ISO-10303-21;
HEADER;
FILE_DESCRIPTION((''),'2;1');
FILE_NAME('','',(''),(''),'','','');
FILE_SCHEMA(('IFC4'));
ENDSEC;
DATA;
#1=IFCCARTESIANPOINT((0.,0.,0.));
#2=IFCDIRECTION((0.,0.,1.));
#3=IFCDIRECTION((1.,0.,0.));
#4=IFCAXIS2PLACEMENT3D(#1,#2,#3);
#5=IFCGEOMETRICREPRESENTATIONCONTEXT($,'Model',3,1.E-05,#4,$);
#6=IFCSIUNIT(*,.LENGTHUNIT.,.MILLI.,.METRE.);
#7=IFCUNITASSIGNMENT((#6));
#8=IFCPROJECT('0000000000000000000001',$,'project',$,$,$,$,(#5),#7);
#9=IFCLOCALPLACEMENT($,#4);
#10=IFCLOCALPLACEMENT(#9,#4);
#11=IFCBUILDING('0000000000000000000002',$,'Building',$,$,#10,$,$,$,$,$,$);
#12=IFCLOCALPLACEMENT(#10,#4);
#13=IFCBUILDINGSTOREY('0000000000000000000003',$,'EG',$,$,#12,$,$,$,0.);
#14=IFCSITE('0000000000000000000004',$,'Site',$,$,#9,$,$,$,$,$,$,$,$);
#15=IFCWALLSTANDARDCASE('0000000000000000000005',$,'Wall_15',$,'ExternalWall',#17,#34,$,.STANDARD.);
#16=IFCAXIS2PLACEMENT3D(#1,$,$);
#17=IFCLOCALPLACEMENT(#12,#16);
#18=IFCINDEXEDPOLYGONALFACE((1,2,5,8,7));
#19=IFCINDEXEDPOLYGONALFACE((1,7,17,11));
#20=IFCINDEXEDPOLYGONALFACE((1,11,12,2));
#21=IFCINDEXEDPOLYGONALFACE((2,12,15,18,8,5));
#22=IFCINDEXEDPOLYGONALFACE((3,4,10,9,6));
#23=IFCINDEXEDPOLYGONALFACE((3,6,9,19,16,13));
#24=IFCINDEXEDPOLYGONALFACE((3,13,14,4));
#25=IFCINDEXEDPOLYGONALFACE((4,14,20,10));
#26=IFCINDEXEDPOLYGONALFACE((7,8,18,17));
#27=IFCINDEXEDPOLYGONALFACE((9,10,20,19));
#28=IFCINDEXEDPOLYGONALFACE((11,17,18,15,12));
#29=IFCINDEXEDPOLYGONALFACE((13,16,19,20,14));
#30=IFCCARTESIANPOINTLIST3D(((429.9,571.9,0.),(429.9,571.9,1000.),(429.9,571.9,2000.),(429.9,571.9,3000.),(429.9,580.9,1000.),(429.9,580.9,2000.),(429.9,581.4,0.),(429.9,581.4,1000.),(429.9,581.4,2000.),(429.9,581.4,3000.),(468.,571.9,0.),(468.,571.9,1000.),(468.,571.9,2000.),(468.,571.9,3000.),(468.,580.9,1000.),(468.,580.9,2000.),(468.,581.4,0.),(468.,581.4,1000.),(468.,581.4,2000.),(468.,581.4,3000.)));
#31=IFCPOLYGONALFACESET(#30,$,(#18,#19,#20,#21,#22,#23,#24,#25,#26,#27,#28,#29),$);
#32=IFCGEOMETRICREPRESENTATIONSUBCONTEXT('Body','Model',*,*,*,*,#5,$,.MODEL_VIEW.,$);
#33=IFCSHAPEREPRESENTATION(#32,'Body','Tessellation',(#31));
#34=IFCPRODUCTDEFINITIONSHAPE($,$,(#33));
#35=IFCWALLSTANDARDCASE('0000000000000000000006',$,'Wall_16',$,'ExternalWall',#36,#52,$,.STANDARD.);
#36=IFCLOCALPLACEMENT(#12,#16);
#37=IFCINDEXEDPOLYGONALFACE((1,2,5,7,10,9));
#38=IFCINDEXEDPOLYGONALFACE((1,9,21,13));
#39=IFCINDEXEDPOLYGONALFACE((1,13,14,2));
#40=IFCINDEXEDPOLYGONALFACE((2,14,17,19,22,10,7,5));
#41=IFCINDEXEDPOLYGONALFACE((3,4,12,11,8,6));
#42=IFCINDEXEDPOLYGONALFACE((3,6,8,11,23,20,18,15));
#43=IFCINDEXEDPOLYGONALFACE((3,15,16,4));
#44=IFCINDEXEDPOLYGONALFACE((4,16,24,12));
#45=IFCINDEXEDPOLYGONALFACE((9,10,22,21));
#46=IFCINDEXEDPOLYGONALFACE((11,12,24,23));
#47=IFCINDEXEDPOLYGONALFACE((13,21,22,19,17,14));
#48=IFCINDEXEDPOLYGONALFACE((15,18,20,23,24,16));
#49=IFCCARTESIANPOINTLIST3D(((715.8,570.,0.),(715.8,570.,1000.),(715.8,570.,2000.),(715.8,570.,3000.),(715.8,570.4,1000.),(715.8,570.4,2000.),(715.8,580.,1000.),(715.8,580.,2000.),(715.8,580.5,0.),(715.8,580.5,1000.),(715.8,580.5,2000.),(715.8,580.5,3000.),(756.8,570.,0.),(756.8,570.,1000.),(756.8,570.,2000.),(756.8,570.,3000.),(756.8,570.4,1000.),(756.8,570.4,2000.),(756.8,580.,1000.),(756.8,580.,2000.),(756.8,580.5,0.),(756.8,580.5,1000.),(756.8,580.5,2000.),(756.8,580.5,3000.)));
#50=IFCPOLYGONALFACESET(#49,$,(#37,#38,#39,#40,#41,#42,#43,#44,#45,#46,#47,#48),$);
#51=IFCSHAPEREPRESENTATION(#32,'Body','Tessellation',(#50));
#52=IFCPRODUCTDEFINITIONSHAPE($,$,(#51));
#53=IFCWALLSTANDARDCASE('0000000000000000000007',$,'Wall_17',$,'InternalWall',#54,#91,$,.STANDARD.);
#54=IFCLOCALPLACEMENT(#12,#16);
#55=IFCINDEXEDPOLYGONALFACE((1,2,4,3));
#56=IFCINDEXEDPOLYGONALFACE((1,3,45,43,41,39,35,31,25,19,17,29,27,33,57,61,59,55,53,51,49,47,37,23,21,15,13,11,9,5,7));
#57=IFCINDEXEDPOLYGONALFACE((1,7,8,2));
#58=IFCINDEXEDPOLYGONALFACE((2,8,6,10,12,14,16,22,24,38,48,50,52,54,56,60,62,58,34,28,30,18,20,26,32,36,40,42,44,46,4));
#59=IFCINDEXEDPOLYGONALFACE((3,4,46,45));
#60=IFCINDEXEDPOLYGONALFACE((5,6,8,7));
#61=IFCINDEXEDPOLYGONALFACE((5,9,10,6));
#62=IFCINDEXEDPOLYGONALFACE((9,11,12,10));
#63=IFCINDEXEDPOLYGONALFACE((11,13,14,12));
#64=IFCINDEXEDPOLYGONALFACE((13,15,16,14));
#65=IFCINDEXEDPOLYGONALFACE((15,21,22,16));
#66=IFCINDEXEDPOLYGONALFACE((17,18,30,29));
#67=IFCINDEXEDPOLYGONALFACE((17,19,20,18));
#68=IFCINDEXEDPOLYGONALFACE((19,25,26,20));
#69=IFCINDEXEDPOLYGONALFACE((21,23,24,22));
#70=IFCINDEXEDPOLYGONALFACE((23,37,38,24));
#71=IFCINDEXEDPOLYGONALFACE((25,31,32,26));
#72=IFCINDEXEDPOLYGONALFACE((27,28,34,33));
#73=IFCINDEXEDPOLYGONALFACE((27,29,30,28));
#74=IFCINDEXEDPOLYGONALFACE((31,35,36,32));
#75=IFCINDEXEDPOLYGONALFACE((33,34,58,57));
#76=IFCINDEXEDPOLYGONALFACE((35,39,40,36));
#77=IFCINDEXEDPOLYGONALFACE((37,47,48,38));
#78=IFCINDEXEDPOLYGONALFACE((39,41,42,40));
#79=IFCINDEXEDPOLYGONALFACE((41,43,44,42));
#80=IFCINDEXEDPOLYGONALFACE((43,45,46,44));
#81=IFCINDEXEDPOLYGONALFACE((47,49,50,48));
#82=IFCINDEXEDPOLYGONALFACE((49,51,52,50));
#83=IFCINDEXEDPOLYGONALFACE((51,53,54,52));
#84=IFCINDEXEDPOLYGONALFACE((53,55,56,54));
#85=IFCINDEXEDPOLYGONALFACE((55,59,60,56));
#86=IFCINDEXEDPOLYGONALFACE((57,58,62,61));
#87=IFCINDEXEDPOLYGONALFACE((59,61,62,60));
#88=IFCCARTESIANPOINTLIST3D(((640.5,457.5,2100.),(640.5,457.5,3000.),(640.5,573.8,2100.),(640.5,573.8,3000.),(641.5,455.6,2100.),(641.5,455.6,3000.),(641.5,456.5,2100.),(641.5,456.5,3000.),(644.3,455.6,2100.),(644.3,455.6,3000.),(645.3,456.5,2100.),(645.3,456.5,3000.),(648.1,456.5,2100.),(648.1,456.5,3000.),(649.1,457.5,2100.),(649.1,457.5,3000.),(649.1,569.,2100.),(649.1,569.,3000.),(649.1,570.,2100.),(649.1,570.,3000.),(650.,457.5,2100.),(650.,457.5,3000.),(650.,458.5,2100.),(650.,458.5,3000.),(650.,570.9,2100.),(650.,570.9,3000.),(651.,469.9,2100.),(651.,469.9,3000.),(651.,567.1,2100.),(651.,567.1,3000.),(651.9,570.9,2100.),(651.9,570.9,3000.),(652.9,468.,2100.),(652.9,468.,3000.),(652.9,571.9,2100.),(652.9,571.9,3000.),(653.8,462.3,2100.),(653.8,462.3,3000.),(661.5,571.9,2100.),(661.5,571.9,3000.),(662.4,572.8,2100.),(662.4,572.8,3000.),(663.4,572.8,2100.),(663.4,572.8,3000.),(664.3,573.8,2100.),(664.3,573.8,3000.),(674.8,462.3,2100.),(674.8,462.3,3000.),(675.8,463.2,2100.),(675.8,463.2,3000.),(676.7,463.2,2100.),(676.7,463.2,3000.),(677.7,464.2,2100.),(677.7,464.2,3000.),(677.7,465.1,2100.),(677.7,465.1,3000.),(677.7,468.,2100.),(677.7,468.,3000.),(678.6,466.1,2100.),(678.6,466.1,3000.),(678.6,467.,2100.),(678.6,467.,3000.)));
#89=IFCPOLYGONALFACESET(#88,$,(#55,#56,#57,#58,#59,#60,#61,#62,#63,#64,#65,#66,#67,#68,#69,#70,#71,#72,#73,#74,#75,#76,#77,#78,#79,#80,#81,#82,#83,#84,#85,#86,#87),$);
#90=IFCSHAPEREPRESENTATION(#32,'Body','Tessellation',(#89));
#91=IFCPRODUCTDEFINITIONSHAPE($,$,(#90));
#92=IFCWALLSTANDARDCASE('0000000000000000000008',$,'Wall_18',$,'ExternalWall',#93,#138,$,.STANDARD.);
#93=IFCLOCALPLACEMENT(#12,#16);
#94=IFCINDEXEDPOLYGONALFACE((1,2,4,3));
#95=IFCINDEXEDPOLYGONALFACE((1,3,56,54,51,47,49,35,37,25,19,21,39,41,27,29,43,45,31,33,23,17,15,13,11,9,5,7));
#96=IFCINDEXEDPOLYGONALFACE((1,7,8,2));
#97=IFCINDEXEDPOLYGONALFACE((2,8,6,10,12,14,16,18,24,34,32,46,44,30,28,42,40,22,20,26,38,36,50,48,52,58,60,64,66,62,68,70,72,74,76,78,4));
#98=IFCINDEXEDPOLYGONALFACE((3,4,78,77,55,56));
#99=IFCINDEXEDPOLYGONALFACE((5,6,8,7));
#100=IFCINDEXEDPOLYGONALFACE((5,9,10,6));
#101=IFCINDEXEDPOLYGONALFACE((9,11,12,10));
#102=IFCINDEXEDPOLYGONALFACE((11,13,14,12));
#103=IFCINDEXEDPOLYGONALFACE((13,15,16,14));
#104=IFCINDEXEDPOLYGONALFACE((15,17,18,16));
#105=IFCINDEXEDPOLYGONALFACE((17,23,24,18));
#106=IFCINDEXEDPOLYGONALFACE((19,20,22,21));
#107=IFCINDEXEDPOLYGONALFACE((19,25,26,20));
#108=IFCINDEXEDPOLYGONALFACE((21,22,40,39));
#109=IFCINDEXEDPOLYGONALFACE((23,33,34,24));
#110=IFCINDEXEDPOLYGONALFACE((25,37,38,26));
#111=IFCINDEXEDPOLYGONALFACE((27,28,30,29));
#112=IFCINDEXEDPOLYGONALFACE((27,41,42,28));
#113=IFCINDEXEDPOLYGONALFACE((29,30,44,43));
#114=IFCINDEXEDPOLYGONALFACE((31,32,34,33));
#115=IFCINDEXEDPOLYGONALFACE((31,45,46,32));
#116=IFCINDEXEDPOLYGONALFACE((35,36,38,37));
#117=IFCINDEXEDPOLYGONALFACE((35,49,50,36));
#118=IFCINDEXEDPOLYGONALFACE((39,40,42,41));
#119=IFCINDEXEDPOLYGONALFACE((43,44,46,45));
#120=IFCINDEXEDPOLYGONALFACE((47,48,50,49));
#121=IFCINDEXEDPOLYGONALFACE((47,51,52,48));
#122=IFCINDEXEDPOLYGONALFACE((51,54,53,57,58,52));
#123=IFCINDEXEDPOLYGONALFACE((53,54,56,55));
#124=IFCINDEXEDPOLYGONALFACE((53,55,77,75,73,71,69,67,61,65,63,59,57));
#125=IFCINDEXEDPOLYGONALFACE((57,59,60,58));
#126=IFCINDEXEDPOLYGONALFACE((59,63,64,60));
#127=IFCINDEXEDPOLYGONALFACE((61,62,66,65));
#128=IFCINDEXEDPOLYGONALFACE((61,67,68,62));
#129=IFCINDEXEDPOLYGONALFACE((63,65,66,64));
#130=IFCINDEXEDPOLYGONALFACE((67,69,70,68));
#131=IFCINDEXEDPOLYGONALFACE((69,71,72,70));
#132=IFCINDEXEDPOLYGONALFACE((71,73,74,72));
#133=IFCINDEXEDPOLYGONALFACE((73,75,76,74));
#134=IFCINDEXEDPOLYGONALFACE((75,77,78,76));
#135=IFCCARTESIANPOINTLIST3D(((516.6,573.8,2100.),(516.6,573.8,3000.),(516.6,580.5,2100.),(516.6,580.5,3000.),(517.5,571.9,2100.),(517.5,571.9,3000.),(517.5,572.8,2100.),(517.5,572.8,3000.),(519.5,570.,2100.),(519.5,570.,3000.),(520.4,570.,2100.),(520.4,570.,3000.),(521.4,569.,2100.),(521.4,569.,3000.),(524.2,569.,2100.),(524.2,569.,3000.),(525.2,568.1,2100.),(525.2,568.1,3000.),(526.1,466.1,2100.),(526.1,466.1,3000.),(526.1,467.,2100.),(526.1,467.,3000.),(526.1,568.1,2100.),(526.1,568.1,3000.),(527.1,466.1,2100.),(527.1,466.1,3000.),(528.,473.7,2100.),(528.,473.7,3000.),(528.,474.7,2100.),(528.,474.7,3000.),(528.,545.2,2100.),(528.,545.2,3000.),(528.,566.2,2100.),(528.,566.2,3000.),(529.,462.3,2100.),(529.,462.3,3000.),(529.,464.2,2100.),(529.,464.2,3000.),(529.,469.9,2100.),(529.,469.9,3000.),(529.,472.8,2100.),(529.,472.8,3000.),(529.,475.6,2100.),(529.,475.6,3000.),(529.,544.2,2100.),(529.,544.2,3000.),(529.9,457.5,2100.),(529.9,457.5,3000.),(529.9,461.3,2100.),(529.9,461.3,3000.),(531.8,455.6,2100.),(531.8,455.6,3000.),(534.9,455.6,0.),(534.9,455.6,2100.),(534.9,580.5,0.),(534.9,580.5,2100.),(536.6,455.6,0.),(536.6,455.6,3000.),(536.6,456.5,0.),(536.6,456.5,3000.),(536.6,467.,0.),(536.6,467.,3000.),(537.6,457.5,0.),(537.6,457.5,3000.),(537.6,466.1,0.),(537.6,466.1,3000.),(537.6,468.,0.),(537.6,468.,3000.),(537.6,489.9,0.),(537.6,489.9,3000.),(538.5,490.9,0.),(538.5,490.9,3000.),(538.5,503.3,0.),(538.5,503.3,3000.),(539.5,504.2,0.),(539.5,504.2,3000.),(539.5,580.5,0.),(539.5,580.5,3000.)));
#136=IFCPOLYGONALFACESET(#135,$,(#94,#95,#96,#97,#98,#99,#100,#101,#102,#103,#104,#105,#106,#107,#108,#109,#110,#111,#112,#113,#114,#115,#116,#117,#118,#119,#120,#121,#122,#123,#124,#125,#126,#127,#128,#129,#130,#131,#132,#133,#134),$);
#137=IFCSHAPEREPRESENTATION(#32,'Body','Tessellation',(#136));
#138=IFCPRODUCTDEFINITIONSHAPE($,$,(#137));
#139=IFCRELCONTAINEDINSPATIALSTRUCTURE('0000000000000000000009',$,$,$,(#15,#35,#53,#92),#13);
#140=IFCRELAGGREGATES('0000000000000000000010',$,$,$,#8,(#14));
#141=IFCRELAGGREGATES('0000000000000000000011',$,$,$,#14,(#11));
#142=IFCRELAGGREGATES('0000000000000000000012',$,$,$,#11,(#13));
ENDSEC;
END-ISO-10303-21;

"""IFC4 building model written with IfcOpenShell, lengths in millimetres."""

from ifc_helpers import new_model, si_unit, frame, origin_with_axes, place, context, subcontext, project, spatial, polyline, rectangle, outline, extrude, element, save


model = new_model("IFC4")

# Units and contexts
model_context = context("Model", 3, precision=1e-05, world=origin_with_axes())
body_context = subcontext(model_context, "Body", "Model", "MODEL_VIEW")
ifc_project = project(units=[si_unit("LENGTHUNIT", "METRE", prefix="MILLI")], contexts=[model_context])

# Site, building, storey
site_placement = place(None, origin_with_axes())
site = spatial("IfcSite", under=ifc_project, at=site_placement, Name="Site")
building_placement = place(site_placement, origin_with_axes())
building = spatial("IfcBuilding", under=site, at=building_placement, Name="Building")
storey_placement = place(building_placement, origin_with_axes())
storey = spatial("IfcBuildingStorey", under=building, at=storey_placement, Name="EG", Elevation=0.0)

# Walls, openings
wall_1_placement = place(storey_placement, origin_with_axes())
wall_1 = element("IfcWallStandardCase", 1, at=wall_1_placement, inside=storey, Name="Wall_15", ObjectType="ExternalWall", PredefinedType="STANDARD", context=body_context, shape_type="SweptSolid", body=[
    extrude(outline(polyline([(429.9, 571.9, 0.0), (429.9, 581.4, 0.0), (468.0, 581.4, 0.0), (468.0, 571.9, 0.0), (429.9, 571.9, 0.0)])), origin_with_axes(), (0.0, 0.0, 1.0), 3000.0),
])
opening_1_placement = place(wall_1_placement, origin_with_axes())
element("IfcOpeningElement", 2, at=opening_1_placement, inside=storey, cuts=wall_1, context=body_context, shape_type="SweptSolid", body=[
    extrude(rectangle(XDim=1200.0, YDim=9.5), frame((403.0, 576.1, 1000.0), z_axis=(0.0, 0.0, 1.0), x_axis=(1.0, 0.0, 0.0)), (0.0, 0.0, 1.0), 1000.0),
])
opening_2_placement = place(wall_1_placement, origin_with_axes())
element("IfcOpeningElement", 3, at=opening_2_placement, inside=storey, cuts=wall_1, context=body_context, shape_type="SweptSolid", body=[
    extrude(rectangle(XDim=1200.0, YDim=9.5), frame((492.2, 576.6, 1000.0), z_axis=(0.0, 0.0, 1.0), x_axis=(1.0, 0.0, 0.0)), (0.0, 0.0, 1.0), 1000.0),
])
wall_2_placement = place(storey_placement, origin_with_axes())
wall_2 = element("IfcWallStandardCase", 4, at=wall_2_placement, inside=storey, Name="Wall_16", ObjectType="ExternalWall", PredefinedType="STANDARD", context=body_context, shape_type="SweptSolid", body=[
    extrude(outline(polyline([(715.8, 570.0, 0.0), (715.8, 580.5, 0.0), (756.8, 580.5, 0.0), (756.8, 570.0, 0.0), (715.8, 570.0, 0.0)])), origin_with_axes(), (0.0, 0.0, 1.0), 3000.0),
])
opening_3_placement = place(wall_2_placement, origin_with_axes())
element("IfcOpeningElement", 5, at=opening_3_placement, inside=storey, cuts=wall_2, context=body_context, shape_type="SweptSolid", body=[
    extrude(rectangle(XDim=1200.0, YDim=10.5), frame((805.3, 574.7, 1000.0), z_axis=(0.0, 0.0, 1.0), x_axis=(1.0, 0.0, 0.0)), (0.0, 0.0, 1.0), 1000.0),
])
opening_4_placement = place(wall_2_placement, origin_with_axes())
element("IfcOpeningElement", 6, at=opening_4_placement, inside=storey, cuts=wall_2, context=body_context, shape_type="SweptSolid", body=[
    extrude(rectangle(XDim=1200.0, YDim=10.5), frame((691.7, 575.6, 1000.0), z_axis=(0.0, 0.0, 1.0), x_axis=(1.0, 0.0, 0.0)), (0.0, 0.0, 1.0), 1000.0),
])
wall_3_placement = place(storey_placement, origin_with_axes())
wall_3 = element("IfcWallStandardCase", 7, at=wall_3_placement, inside=storey, Name="Wall_17", ObjectType="InternalWall", PredefinedType="STANDARD", context=body_context, shape_type="SweptSolid", body=[
    extrude(outline(polyline([(641.5, 455.6, 0.0), (641.5, 456.5, 0.0), (640.5, 457.5, 0.0), (640.5, 573.8, 0.0), (664.3, 573.8, 0.0), (663.4, 572.8, 0.0), (662.4, 572.8, 0.0), (661.5, 571.9, 0.0), (652.9, 571.9, 0.0), (651.9, 570.9, 0.0), (650.0, 570.9, 0.0), (649.1, 570.0, 0.0), (649.1, 569.0, 0.0), (651.0, 567.1, 0.0), (651.0, 469.9, 0.0), (652.9, 468.0, 0.0), (677.7, 468.0, 0.0), (678.6, 467.0, 0.0), (678.6, 466.1, 0.0), (677.7, 465.1, 0.0), (677.7, 464.2, 0.0), (676.7, 463.2, 0.0), (675.8, 463.2, 0.0), (674.8, 462.3, 0.0), (653.8, 462.3, 0.0), (650.0, 458.5, 0.0), (650.0, 457.5, 0.0), (649.1, 457.5, 0.0), (648.1, 456.5, 0.0), (645.3, 456.5, 0.0), (644.3, 455.6, 0.0), (641.5, 455.6, 0.0)])), origin_with_axes(), (0.0, 0.0, 1.0), 3000.0),
])
opening_5_placement = place(wall_3_placement, origin_with_axes())
element("IfcOpeningElement", 8, at=opening_5_placement, inside=storey, cuts=wall_3, context=body_context, shape_type="SweptSolid", body=[
    extrude(rectangle(XDim=450.0, YDim=38.1), frame((659.6, 456.1, 0.0), z_axis=(0.0, 0.0, 1.0), x_axis=(0.0, 1.0, 0.0)), (0.0, 0.0, 1.0), 2100.0),
])
opening_6_placement = place(wall_3_placement, origin_with_axes())
element("IfcOpeningElement", 9, at=opening_6_placement, inside=storey, cuts=wall_3, context=body_context, shape_type="SweptSolid", body=[
    extrude(rectangle(XDim=600.0, YDim=38.1), frame((659.6, 572.8, 1000.0), z_axis=(0.0, 0.0, 1.0), x_axis=(0.0, 1.0, 0.0)), (0.0, 0.0, 1.0), 1000.0),
])
opening_7_placement = place(wall_3_placement, origin_with_axes())
element("IfcOpeningElement", 10, at=opening_7_placement, inside=storey, cuts=wall_3, context=body_context, shape_type="SweptSolid", body=[
    extrude(rectangle(XDim=600.0, YDim=38.1), frame((659.6, 539.9, 1000.0), z_axis=(0.0, 0.0, 1.0), x_axis=(0.0, 1.0, 0.0)), (0.0, 0.0, 1.0), 1000.0),
])

# Wall, opening
wall_4_placement = place(storey_placement, origin_with_axes())
wall_4 = element("IfcWallStandardCase", 11, at=wall_4_placement, inside=storey, Name="Wall_18", ObjectType="ExternalWall", PredefinedType="STANDARD", context=body_context, shape_type="SweptSolid", body=[
    extrude(outline(polyline([(531.8, 455.6, 0.0), (529.9, 457.5, 0.0), (529.9, 461.3, 0.0), (529.0, 462.3, 0.0), (529.0, 464.2, 0.0), (527.1, 466.1, 0.0), (526.1, 466.1, 0.0), (526.1, 467.0, 0.0), (529.0, 469.9, 0.0), (529.0, 472.8, 0.0), (528.0, 473.7, 0.0), (528.0, 474.7, 0.0), (529.0, 475.6, 0.0), (529.0, 544.2, 0.0), (528.0, 545.2, 0.0), (528.0, 566.2, 0.0), (526.1, 568.1, 0.0), (525.2, 568.1, 0.0), (524.2, 569.0, 0.0), (521.4, 569.0, 0.0), (520.4, 570.0, 0.0), (519.5, 570.0, 0.0), (517.5, 571.9, 0.0), (517.5, 572.8, 0.0), (516.6, 573.8, 0.0), (516.6, 580.5, 0.0), (539.5, 580.5, 0.0), (539.5, 504.2, 0.0), (538.5, 503.3, 0.0), (538.5, 490.9, 0.0), (537.6, 489.9, 0.0), (537.6, 468.0, 0.0), (536.6, 467.0, 0.0), (537.6, 466.1, 0.0), (537.6, 457.5, 0.0), (536.6, 456.5, 0.0), (536.6, 455.6, 0.0), (531.8, 455.6, 0.0)])), origin_with_axes(), (0.0, 0.0, 1.0), 3000.0),
])
opening_8_placement = place(wall_4_placement, origin_with_axes())
element("IfcOpeningElement", 12, at=opening_8_placement, inside=storey, cuts=wall_4, context=body_context, shape_type="SweptSolid", body=[
    extrude(rectangle(XDim=900.0, YDim=22.9), frame((523.4, 438.6, 0.0), z_axis=(0.0, 0.0, 1.0), x_axis=(0.0, 1.0, 0.0)), (0.0, 0.0, 1.0), 2100.0),
])

save(model, "model.ifc")
